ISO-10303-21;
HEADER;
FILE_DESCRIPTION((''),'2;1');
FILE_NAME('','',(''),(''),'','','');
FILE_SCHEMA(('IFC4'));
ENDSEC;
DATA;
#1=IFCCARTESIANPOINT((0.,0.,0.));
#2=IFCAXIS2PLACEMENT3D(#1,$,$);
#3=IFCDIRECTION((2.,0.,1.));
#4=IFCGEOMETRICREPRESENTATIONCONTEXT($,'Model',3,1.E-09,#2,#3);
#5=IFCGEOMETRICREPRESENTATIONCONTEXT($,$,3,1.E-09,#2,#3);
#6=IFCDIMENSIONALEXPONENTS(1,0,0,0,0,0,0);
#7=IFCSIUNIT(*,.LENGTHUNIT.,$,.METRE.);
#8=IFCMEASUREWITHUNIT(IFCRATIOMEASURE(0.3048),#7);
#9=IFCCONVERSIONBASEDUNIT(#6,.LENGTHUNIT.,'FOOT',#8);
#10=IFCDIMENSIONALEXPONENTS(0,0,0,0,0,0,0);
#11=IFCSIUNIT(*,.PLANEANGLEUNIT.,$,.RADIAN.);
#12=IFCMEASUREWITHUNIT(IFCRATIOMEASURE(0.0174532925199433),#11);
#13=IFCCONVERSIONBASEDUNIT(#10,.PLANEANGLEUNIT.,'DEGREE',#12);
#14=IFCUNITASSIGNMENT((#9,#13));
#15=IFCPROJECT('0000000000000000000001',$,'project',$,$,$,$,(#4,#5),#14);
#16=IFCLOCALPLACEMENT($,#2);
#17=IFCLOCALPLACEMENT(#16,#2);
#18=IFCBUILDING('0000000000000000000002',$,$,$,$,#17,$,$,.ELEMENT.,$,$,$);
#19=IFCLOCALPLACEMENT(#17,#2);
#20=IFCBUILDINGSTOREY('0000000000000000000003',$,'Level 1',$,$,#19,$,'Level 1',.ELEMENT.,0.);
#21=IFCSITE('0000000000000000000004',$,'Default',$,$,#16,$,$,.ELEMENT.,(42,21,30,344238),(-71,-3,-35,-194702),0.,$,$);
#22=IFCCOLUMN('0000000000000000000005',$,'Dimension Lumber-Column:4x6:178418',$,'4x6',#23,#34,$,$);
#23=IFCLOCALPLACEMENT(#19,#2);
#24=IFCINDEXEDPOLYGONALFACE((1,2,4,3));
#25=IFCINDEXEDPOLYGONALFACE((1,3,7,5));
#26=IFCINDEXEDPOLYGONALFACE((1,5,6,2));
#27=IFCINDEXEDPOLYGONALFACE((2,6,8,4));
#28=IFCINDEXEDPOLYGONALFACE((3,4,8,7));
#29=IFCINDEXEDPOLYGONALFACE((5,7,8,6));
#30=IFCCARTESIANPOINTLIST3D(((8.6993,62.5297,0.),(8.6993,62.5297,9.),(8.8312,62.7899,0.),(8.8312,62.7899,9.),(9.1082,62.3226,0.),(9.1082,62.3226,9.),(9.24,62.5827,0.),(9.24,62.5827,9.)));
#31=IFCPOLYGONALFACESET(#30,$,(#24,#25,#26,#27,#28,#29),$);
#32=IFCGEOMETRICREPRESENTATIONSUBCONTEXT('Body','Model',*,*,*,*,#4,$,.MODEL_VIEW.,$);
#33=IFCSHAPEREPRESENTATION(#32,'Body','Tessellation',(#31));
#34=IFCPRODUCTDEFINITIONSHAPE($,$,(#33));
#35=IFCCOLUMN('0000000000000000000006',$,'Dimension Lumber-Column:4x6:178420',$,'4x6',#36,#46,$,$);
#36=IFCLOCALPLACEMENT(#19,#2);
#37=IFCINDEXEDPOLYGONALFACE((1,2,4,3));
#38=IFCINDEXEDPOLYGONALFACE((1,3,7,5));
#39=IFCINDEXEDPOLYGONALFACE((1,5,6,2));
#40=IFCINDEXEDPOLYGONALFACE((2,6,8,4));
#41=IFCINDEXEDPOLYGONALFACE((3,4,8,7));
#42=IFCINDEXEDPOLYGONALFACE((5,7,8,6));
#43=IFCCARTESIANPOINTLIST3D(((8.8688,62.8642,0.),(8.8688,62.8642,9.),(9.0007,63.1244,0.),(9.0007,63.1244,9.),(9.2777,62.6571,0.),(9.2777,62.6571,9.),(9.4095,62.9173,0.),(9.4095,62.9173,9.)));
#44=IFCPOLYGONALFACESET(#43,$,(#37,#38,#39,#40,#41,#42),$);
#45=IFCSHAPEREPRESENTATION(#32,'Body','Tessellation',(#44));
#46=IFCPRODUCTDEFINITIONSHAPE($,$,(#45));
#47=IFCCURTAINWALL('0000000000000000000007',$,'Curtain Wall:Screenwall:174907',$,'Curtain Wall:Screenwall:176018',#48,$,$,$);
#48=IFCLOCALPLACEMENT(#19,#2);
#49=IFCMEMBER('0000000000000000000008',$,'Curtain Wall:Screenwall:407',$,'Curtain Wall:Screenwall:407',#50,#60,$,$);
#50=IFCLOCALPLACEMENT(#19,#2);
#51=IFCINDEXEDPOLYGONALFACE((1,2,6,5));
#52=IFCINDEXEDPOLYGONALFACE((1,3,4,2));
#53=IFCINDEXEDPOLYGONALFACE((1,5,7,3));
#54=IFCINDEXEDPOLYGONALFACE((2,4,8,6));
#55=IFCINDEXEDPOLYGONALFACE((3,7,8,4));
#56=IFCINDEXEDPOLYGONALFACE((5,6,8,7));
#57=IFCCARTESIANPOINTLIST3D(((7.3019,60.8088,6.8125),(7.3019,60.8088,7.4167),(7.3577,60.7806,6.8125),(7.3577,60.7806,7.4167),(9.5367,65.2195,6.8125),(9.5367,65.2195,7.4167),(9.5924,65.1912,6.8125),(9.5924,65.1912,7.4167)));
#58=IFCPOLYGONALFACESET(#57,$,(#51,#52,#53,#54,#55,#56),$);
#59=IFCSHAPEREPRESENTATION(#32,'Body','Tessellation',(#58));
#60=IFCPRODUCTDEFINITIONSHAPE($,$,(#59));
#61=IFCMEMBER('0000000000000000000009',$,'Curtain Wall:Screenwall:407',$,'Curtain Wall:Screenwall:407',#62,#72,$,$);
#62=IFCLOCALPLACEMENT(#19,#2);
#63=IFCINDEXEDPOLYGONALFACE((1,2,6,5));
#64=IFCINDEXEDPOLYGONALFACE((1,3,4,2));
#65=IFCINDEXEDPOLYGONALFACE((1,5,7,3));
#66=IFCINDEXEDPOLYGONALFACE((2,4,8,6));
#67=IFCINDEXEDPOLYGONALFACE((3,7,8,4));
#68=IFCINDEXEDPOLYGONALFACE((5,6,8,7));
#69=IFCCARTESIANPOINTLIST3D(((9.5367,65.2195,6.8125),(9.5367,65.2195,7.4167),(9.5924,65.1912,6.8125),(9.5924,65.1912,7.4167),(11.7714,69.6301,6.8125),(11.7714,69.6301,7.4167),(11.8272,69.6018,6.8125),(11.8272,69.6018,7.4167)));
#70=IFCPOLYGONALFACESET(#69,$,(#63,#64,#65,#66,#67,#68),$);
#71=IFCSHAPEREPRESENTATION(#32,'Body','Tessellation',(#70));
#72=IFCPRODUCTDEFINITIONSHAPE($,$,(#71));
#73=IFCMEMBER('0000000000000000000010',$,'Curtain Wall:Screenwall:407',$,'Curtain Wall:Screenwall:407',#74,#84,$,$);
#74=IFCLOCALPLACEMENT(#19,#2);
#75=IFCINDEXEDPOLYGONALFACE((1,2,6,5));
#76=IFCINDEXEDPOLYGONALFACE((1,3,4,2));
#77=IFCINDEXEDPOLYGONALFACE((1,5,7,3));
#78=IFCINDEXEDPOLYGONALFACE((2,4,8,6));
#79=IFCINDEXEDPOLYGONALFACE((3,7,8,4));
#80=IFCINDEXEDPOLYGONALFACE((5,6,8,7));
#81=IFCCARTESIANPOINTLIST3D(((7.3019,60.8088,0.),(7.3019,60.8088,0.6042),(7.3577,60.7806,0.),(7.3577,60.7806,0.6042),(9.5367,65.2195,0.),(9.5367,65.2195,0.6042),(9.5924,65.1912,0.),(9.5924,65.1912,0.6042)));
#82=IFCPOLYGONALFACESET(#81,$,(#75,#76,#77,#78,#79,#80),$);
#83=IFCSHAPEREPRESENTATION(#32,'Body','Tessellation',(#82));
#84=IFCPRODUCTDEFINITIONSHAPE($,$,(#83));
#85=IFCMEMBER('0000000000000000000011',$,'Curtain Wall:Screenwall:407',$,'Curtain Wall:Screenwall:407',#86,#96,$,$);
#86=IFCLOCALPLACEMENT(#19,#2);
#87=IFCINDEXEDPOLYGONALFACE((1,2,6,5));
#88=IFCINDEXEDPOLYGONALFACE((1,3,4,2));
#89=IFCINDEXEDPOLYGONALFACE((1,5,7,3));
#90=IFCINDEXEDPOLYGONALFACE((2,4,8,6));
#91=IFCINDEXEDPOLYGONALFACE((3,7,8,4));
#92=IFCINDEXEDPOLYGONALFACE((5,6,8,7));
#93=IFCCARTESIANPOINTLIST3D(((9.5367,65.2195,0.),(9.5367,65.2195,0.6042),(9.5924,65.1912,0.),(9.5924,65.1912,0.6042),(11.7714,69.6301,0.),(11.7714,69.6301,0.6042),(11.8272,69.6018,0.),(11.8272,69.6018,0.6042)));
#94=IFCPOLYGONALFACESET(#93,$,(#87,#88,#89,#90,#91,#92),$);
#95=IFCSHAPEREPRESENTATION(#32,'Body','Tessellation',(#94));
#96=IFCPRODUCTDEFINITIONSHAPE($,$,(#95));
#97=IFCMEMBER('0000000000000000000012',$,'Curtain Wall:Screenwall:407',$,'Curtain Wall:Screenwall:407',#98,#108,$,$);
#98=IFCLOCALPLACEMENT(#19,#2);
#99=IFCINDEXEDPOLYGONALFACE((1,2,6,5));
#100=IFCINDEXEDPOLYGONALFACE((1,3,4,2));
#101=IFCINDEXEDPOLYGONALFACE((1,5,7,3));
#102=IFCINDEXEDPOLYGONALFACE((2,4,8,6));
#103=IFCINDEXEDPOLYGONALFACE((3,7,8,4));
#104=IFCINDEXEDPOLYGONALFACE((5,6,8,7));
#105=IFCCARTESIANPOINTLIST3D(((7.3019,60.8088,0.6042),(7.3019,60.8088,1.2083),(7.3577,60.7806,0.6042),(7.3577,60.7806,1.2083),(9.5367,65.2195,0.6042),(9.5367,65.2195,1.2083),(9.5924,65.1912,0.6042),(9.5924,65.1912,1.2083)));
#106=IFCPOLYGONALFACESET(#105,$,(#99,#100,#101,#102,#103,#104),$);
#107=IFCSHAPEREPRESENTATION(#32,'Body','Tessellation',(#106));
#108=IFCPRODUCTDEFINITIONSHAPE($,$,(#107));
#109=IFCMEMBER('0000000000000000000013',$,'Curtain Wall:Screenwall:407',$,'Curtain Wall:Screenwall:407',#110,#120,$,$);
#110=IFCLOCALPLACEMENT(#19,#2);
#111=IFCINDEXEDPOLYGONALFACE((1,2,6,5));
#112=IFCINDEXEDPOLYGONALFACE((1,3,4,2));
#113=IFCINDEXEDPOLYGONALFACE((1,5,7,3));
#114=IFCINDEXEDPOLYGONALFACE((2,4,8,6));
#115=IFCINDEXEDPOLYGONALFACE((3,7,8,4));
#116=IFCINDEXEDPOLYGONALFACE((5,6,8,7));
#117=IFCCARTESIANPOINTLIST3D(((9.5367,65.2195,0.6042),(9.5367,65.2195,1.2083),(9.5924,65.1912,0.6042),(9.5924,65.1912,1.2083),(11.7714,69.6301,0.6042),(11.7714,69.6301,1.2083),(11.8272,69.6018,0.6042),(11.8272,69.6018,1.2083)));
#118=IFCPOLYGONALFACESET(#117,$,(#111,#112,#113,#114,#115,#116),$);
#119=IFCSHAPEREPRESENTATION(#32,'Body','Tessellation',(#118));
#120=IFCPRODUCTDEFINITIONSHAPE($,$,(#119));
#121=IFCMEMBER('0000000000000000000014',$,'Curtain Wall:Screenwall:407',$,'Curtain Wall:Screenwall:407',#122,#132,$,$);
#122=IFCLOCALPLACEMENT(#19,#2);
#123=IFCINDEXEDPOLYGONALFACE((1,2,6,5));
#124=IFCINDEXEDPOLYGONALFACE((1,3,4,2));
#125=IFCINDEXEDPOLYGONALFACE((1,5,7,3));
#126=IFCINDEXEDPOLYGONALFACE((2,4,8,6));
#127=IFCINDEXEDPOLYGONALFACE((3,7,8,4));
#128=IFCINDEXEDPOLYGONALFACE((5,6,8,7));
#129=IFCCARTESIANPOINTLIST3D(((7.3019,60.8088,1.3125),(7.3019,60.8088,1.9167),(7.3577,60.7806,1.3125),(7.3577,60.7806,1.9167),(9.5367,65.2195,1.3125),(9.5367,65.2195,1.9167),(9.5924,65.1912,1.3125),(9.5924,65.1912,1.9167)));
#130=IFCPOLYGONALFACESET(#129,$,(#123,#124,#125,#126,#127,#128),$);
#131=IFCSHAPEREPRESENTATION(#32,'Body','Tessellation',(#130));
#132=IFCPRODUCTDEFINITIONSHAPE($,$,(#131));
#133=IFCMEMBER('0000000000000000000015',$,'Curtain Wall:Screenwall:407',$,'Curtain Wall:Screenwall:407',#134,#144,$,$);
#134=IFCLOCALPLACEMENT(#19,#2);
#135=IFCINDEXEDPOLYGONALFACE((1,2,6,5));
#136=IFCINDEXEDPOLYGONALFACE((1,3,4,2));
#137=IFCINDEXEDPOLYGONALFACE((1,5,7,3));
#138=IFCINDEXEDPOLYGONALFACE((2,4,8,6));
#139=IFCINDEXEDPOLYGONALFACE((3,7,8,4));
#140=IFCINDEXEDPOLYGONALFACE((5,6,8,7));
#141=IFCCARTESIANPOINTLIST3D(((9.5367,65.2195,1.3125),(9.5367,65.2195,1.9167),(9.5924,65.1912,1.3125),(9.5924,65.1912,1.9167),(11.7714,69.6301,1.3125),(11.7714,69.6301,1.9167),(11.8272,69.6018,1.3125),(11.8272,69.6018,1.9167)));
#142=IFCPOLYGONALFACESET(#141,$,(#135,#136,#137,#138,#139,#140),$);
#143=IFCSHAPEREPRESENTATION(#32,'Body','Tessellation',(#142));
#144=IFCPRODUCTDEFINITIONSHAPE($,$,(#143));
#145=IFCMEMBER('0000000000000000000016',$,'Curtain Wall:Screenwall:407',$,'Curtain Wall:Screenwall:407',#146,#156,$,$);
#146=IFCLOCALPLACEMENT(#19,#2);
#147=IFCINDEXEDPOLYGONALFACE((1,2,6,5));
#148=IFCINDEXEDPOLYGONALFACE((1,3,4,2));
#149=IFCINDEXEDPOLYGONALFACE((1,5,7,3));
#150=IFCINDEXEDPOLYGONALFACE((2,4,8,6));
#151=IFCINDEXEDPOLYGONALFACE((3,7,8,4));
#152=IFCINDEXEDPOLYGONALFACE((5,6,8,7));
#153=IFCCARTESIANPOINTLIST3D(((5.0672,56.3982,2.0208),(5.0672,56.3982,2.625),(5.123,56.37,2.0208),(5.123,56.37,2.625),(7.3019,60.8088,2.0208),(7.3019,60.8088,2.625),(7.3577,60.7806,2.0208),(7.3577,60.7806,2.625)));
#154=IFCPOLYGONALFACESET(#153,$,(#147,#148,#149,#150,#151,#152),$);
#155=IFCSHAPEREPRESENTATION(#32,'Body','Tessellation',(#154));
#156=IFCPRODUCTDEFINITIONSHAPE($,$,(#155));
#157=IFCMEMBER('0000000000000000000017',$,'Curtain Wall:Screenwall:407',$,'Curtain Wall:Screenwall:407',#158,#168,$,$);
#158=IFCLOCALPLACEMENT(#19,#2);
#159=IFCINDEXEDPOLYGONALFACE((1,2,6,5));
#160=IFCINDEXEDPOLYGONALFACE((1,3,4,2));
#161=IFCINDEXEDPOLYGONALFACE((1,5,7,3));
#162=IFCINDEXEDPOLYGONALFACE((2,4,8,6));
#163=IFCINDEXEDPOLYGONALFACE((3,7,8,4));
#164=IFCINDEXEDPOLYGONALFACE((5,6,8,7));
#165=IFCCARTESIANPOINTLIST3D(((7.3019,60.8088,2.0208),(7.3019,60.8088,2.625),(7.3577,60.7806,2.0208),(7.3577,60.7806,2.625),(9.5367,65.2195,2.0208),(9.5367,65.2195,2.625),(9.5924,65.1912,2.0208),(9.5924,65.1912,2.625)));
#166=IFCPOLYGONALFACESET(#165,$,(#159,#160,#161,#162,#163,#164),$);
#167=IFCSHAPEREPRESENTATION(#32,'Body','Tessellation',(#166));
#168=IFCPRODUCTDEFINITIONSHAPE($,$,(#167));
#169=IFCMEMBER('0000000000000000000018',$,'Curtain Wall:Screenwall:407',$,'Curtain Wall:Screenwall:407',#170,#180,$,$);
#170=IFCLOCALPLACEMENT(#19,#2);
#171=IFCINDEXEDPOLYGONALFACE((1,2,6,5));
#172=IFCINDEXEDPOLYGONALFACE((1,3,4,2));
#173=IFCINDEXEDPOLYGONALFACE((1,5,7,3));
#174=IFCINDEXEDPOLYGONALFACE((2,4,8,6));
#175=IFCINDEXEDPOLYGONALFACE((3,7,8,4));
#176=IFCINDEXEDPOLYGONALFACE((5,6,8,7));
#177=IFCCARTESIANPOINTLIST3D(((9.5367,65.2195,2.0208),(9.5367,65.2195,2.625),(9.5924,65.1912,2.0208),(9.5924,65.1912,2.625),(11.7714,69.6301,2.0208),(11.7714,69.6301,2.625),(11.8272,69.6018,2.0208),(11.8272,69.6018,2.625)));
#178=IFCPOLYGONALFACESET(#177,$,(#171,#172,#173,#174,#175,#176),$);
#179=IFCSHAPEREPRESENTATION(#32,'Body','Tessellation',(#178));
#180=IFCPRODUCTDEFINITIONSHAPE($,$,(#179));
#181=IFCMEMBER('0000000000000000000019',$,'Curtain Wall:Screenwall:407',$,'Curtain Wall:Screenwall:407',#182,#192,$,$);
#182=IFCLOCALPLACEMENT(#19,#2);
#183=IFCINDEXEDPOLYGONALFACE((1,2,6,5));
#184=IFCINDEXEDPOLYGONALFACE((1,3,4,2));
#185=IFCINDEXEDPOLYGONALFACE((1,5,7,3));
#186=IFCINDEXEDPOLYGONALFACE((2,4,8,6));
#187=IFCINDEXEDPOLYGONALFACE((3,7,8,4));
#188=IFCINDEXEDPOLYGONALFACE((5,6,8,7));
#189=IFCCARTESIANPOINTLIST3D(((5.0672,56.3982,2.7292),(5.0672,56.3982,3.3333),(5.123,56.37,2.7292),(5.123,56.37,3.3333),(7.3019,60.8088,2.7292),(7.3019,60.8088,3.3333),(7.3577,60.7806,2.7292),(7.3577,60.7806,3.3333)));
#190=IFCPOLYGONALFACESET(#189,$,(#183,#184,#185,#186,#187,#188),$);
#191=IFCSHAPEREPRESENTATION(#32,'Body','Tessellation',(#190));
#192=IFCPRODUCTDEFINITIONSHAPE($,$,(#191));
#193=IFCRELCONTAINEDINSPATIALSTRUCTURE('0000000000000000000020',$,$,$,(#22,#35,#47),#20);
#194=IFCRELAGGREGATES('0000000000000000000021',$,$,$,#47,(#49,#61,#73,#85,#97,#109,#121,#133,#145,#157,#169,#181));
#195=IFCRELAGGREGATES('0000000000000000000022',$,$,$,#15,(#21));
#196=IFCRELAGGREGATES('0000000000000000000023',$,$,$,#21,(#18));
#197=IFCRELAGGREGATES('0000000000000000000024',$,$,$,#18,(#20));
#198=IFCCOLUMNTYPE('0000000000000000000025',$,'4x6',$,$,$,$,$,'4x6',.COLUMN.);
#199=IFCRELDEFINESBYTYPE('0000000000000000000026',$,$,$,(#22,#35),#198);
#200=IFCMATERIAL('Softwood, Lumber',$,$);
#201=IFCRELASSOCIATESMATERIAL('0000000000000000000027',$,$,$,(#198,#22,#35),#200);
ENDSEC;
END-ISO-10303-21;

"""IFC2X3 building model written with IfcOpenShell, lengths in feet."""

from ifc_helpers import new_model, entity, si_unit, converted_unit, direction, frame, frame_2d, origin, origin_2d_with_axis, place, context, subcontext, project, spatial, rectangle, extrude, source, transform, mapped, material, type_object, type_shapes, element, aggregate, save


model = new_model("IFC2X3")

# Units and contexts
model_context = context("Model", 3, precision=1e-09, world=origin(), true_north=direction((2.0, 0.0, 1.0)))
context_of_model = context(None, 3, precision=1e-09, world=origin(), true_north=direction((2.0, 0.0, 1.0)))
body_context = subcontext(model_context, "Body", "Model", "MODEL_VIEW")
ifc_project = project(units=[converted_unit("LENGTHUNIT", "FOOT", entity("IfcRatioMeasure", 0.3048), si_unit("LENGTHUNIT", "METRE"), dimensions=[1, 0, 0, 0, 0, 0, 0]), converted_unit("PLANEANGLEUNIT", "DEGREE", entity("IfcRatioMeasure", 0.0174532925199433), si_unit("PLANEANGLEUNIT", "RADIAN"), dimensions=[0, 0, 0, 0, 0, 0, 0])], contexts=[model_context, context_of_model])

# Site, building, storey
site_placement = place(None, origin())
site = spatial("IfcSite", under=ifc_project, at=site_placement, Name="Default", CompositionType="ELEMENT", RefLatitude=(42, 21, 30, 344238), RefLongitude=(-71, -3, -35, -194702), RefElevation=0.0)
building_placement = place(site_placement, origin())
building = spatial("IfcBuilding", under=site, at=building_placement, CompositionType="ELEMENT")
storey_placement = place(building_placement, origin())
storey = spatial("IfcBuildingStorey", under=building, at=storey_placement, Name="Level 1", LongName="Level 1", CompositionType="ELEMENT", Elevation=0.0)

# Columns
ifc_material = material(Name="Softwood, Lumber")
column_type = type_object("IfcColumnType", Name="4x6", ElementType="4x6", PredefinedType="COLUMN", material=ifc_material)
shared_shape = source(origin(), body_context, "Body", "SweptSolid", [
    extrude(rectangle(XDim=0.2917, YDim=0.4583, at=origin_2d_with_axis()), frame((0.0, 0.0, 0.0), z_axis=(0.0, 0.0, 1.0), x_axis=(-1.0, 0.0, 0.0)), (0.0, 0.0, 1.0), 9.0),
])
type_shapes(column_type, [shared_shape])
for number, where, z_axis, x_axis, name in (
    (1, (8.9697, 62.5562, 0.0), (0.0, 0.0, 1.0), (0.451968, 0.892034, 0.0), "Dimension Lumber-Column:4x6:178418"),
    (2, (9.1392, 62.8907, 0.0), (0.0, 0.0, 1.0), (0.451968, 0.892034, 0.0), "Dimension Lumber-Column:4x6:178420"),
):
    element("IfcColumn", number, at=place(storey_placement, frame(where, z_axis=z_axis, x_axis=x_axis)), inside=storey, type_object=column_type, material=ifc_material, Name=name, ObjectType="4x6", context=body_context, shape_type="MappedRepresentation", body=[
        mapped(shared_shape, transform((0.0, 0.0, 0.0), scale=1.0)),
    ])

# Curtain wall, members
curtain_wall_placement = place(storey_placement, origin())
curtain_wall = element("IfcCurtainWall", 3, at=curtain_wall_placement, inside=storey, Name="Curtain Wall:Screenwall:174907", ObjectType="Curtain Wall:Screenwall:176018")
member_1_placement = place(curtain_wall_placement, frame((7.3019, 60.7806, 6.8125)))
member_1 = element("IfcMember", 4, at=member_1_placement, Name="Curtain Wall:Screenwall:407", ObjectType="Curtain Wall:Screenwall:407", context=body_context, shape_type="SweptSolid", body=[
    extrude(rectangle(XDim=4.9444, YDim=0.0625, at=frame_2d((0.0, 0.0), x_axis=(1.0, 0.0))), frame((1.1452, 2.2194, 0.0), z_axis=(0.0, 0.0, 1.0), x_axis=(-0.451968, -0.892034, 0.0)), (0.0, 0.0, 1.0), 0.6042),
])
member_2_placement = place(curtain_wall_placement, frame((9.5367, 65.1912, 6.8125)))
member_2 = element("IfcMember", 5, at=member_2_placement, Name="Curtain Wall:Screenwall:407", ObjectType="Curtain Wall:Screenwall:407", context=body_context, shape_type="SweptSolid", body=[
    extrude(rectangle(XDim=4.9444, YDim=0.0625, at=frame_2d((0.0, 0.0), x_axis=(1.0, 0.0))), frame((1.1452, 2.2194, 0.0), z_axis=(0.0, 0.0, 1.0), x_axis=(-0.451968, -0.892034, 0.0)), (0.0, 0.0, 1.0), 0.6042),
])
member_3_placement = place(curtain_wall_placement, frame((7.3019, 60.7806, 0.0)))
member_3 = element("IfcMember", 6, at=member_3_placement, Name="Curtain Wall:Screenwall:407", ObjectType="Curtain Wall:Screenwall:407", context=body_context, shape_type="SweptSolid", body=[
    extrude(rectangle(XDim=4.9444, YDim=0.0625, at=frame_2d((0.0, 0.0), x_axis=(1.0, 0.0))), frame((1.1452, 2.2194, 0.0), z_axis=(0.0, 0.0, 1.0), x_axis=(0.451968, 0.892034, 0.0)), (0.0, 0.0, 1.0), 0.6042),
])
member_4_placement = place(curtain_wall_placement, frame((9.5367, 65.1912, 0.0)))
member_4 = element("IfcMember", 7, at=member_4_placement, Name="Curtain Wall:Screenwall:407", ObjectType="Curtain Wall:Screenwall:407", context=body_context, shape_type="SweptSolid", body=[
    extrude(rectangle(XDim=4.9444, YDim=0.0625, at=frame_2d((0.0, 0.0), x_axis=(1.0, 0.0))), frame((1.1452, 2.2194, 0.0), z_axis=(0.0, 0.0, 1.0), x_axis=(0.451968, 0.892034, 0.0)), (0.0, 0.0, 1.0), 0.6042),
])
member_5_placement = place(curtain_wall_placement, frame((7.3019, 60.7806, 0.6042)))
member_5 = element("IfcMember", 8, at=member_5_placement, Name="Curtain Wall:Screenwall:407", ObjectType="Curtain Wall:Screenwall:407", context=body_context, shape_type="SweptSolid", body=[
    extrude(rectangle(XDim=4.9444, YDim=0.0625, at=frame_2d((0.0, 0.0), x_axis=(1.0, 0.0))), frame((1.1452, 2.2194, 0.0), z_axis=(0.0, 0.0, 1.0), x_axis=(-0.451968, -0.892034, 0.0)), (0.0, 0.0, 1.0), 0.6042),
])
member_6_placement = place(curtain_wall_placement, frame((9.5367, 65.1912, 0.6042)))
member_6 = element("IfcMember", 9, at=member_6_placement, Name="Curtain Wall:Screenwall:407", ObjectType="Curtain Wall:Screenwall:407", context=body_context, shape_type="SweptSolid", body=[
    extrude(rectangle(XDim=4.9444, YDim=0.0625, at=frame_2d((0.0, 0.0), x_axis=(1.0, 0.0))), frame((1.1452, 2.2194, 0.0), z_axis=(0.0, 0.0, 1.0), x_axis=(-0.451968, -0.892034, 0.0)), (0.0, 0.0, 1.0), 0.6042),
])
member_7_placement = place(curtain_wall_placement, frame((7.3019, 60.7806, 1.3125)))
member_7 = element("IfcMember", 10, at=member_7_placement, Name="Curtain Wall:Screenwall:407", ObjectType="Curtain Wall:Screenwall:407", context=body_context, shape_type="SweptSolid", body=[
    extrude(rectangle(XDim=4.9444, YDim=0.0625, at=frame_2d((0.0, 0.0), x_axis=(1.0, 0.0))), frame((1.1452, 2.2194, 0.0), z_axis=(0.0, 0.0, 1.0), x_axis=(-0.451968, -0.892034, 0.0)), (0.0, 0.0, 1.0), 0.6042),
])
member_8_placement = place(curtain_wall_placement, frame((9.5367, 65.1912, 1.3125)))
member_8 = element("IfcMember", 11, at=member_8_placement, Name="Curtain Wall:Screenwall:407", ObjectType="Curtain Wall:Screenwall:407", context=body_context, shape_type="SweptSolid", body=[
    extrude(rectangle(XDim=4.9444, YDim=0.0625, at=frame_2d((0.0, 0.0), x_axis=(1.0, 0.0))), frame((1.1452, 2.2194, 0.0), z_axis=(0.0, 0.0, 1.0), x_axis=(-0.451968, -0.892034, 0.0)), (0.0, 0.0, 1.0), 0.6042),
])
member_9_placement = place(curtain_wall_placement, frame((5.0672, 56.37, 2.0208)))
member_9 = element("IfcMember", 12, at=member_9_placement, Name="Curtain Wall:Screenwall:407", ObjectType="Curtain Wall:Screenwall:407", context=body_context, shape_type="SweptSolid", body=[
    extrude(rectangle(XDim=4.9444, YDim=0.0625, at=frame_2d((0.0, 0.0), x_axis=(1.0, 0.0))), frame((1.1452, 2.2194, 0.0), z_axis=(0.0, 0.0, 1.0), x_axis=(-0.451968, -0.892034, 0.0)), (0.0, 0.0, 1.0), 0.6042),
])
member_10_placement = place(curtain_wall_placement, frame((7.3019, 60.7806, 2.0208)))
member_10 = element("IfcMember", 13, at=member_10_placement, Name="Curtain Wall:Screenwall:407", ObjectType="Curtain Wall:Screenwall:407", context=body_context, shape_type="SweptSolid", body=[
    extrude(rectangle(XDim=4.9444, YDim=0.0625, at=frame_2d((0.0, 0.0), x_axis=(1.0, 0.0))), frame((1.1452, 2.2194, 0.0), z_axis=(0.0, 0.0, 1.0), x_axis=(-0.451968, -0.892034, 0.0)), (0.0, 0.0, 1.0), 0.6042),
])
member_11_placement = place(curtain_wall_placement, frame((9.5367, 65.1912, 2.0208)))
member_11 = element("IfcMember", 14, at=member_11_placement, Name="Curtain Wall:Screenwall:407", ObjectType="Curtain Wall:Screenwall:407", context=body_context, shape_type="SweptSolid", body=[
    extrude(rectangle(XDim=4.9444, YDim=0.0625, at=frame_2d((0.0, 0.0), x_axis=(1.0, 0.0))), frame((1.1452, 2.2194, 0.0), z_axis=(0.0, 0.0, 1.0), x_axis=(-0.451968, -0.892034, 0.0)), (0.0, 0.0, 1.0), 0.6042),
])
member_12_placement = place(curtain_wall_placement, frame((5.0672, 56.37, 2.7292)))
member_12 = element("IfcMember", 15, at=member_12_placement, Name="Curtain Wall:Screenwall:407", ObjectType="Curtain Wall:Screenwall:407", context=body_context, shape_type="SweptSolid", body=[
    extrude(rectangle(XDim=4.9444, YDim=0.0625, at=frame_2d((0.0, 0.0), x_axis=(1.0, 0.0))), frame((1.1452, 2.2194, 0.0), z_axis=(0.0, 0.0, 1.0), x_axis=(-0.451968, -0.892034, 0.0)), (0.0, 0.0, 1.0), 0.6042),
])
aggregate(curtain_wall, [member_1, member_2, member_3, member_4, member_5, member_6, member_7, member_8, member_9, member_10, member_11, member_12])

save(model, "model.ifc")
